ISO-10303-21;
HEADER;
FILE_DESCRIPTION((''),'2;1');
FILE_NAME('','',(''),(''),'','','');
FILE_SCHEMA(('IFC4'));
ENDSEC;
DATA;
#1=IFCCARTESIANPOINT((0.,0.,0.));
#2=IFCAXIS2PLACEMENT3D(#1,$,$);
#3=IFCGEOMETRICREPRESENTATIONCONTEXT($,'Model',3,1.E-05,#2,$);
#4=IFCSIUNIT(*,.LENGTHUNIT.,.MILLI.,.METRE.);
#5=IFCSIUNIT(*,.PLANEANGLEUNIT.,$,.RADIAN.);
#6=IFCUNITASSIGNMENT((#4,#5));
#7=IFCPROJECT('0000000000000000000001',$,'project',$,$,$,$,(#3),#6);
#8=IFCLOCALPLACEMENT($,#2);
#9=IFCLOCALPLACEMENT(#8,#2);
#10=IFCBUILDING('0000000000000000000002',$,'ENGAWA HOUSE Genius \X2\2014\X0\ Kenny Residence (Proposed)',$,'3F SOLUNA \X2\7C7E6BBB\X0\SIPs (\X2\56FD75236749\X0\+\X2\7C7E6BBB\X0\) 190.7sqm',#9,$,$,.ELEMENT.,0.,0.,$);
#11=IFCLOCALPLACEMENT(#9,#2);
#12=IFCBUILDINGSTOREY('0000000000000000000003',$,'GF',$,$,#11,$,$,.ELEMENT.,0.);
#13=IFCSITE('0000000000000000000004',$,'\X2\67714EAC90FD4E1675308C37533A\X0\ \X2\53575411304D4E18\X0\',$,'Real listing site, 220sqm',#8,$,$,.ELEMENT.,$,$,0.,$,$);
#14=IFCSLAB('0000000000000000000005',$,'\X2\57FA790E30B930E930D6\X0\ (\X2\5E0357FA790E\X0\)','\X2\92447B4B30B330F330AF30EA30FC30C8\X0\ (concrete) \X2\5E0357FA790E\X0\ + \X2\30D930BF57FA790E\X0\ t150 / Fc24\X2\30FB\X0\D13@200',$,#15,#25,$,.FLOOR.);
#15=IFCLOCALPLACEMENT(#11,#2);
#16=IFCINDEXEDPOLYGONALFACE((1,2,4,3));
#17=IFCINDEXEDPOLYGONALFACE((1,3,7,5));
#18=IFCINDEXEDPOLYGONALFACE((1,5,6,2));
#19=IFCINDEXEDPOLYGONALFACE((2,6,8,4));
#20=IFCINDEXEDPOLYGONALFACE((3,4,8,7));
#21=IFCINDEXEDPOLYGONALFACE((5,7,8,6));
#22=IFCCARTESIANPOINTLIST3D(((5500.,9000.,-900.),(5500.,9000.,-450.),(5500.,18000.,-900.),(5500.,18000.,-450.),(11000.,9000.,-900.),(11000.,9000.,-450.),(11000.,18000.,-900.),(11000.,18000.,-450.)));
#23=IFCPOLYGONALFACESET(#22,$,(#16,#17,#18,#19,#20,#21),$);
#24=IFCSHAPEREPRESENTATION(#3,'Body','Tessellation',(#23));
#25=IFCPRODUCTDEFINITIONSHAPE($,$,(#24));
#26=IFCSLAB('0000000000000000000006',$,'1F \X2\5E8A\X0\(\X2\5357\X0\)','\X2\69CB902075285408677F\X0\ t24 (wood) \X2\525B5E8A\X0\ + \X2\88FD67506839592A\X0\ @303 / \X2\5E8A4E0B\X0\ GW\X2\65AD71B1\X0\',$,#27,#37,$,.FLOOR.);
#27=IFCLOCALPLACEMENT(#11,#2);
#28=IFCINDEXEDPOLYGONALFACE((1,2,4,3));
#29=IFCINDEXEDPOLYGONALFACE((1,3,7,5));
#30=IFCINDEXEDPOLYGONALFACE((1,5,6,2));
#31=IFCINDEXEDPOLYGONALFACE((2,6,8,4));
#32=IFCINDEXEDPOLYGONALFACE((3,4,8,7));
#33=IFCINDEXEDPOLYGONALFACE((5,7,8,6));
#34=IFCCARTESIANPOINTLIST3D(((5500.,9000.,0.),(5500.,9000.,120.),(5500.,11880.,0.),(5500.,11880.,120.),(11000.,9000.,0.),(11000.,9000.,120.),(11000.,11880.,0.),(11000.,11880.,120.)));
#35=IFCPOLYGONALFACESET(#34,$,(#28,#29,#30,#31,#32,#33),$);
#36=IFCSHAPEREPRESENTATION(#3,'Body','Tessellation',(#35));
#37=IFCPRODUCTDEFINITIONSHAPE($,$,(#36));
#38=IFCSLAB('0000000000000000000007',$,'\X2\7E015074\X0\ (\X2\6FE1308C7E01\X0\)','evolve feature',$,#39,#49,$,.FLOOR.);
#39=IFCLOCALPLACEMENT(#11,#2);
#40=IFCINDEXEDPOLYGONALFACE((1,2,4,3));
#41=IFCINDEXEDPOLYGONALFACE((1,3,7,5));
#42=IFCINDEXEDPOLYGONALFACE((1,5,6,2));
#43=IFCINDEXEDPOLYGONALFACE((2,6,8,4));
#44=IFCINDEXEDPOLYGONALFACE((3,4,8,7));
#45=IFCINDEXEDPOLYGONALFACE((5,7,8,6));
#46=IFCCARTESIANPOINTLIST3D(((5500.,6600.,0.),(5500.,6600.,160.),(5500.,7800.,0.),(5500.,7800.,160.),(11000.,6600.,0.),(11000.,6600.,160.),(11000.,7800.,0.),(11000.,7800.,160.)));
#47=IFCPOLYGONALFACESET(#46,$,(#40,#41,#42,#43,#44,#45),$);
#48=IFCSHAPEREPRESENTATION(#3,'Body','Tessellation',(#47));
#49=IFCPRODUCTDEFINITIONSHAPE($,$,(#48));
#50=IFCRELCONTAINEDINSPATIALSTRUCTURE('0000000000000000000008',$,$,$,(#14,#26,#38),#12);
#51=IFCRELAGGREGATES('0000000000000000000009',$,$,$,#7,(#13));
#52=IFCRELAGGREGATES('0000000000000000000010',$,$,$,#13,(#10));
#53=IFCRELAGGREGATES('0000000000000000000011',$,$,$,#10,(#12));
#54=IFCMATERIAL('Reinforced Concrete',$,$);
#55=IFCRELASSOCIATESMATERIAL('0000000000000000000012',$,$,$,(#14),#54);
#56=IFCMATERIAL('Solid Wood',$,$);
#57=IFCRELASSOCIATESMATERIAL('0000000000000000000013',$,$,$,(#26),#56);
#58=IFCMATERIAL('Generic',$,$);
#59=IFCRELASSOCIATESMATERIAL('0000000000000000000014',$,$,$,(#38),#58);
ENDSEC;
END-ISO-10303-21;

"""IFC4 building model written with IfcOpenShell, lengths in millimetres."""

from ifc_helpers import new_model, si_unit, frame, frame_2d, origin, place, context, project, spatial, rectangle, extrude, material, element, save


model = new_model("IFC4")

# Units and contexts
model_context = context("Model", 3, precision=1e-05, world=origin())
ifc_project = project(units=[si_unit("LENGTHUNIT", "METRE", prefix="MILLI"), si_unit("PLANEANGLEUNIT", "RADIAN")], contexts=[model_context])

# Site, building, storey
site_placement = place(None, origin())
site = spatial("IfcSite", under=ifc_project, at=site_placement, Name="東京都世田谷区 南向き丘", ObjectType="Real listing site, 220sqm", CompositionType="ELEMENT", RefElevation=0.0)
building_placement = place(site_placement, origin())
building = spatial("IfcBuilding", under=site, at=building_placement, Name="ENGAWA HOUSE Genius — Kenny Residence (Proposed)", ObjectType="3F SOLUNA 籾殻SIPs (国産杉+籾殻) 190.7sqm", CompositionType="ELEMENT", ElevationOfRefHeight=0.0, ElevationOfTerrain=0.0)
storey_placement = place(building_placement, origin())
storey = spatial("IfcBuildingStorey", under=building, at=storey_placement, Name="GF", CompositionType="ELEMENT", Elevation=0.0)

# Slabs
ifc_material_1 = material(Name="Reinforced Concrete")
slab_1_placement = place(storey_placement, frame((2750.0, 4500.0, -450.0)))
element("IfcSlab", 1, at=slab_1_placement, inside=storey, material=ifc_material_1, Name="基礎スラブ (布基礎)", Description="鉄筋コンクリート (concrete) 布基礎 + ベタ基礎 t150 / Fc24・D13@200", PredefinedType="FLOOR", context=model_context, shape_type="SweptSolid", body=[
    extrude(rectangle(XDim=5500.0, YDim=9000.0, at=frame_2d((2750.0, 4500.0))), frame((2750.0, 4500.0, -450.0)), (0.0, 0.0, 1.0), 450.0),
])
ifc_material_2 = material(Name="Solid Wood")
slab_2_placement = place(storey_placement, frame((2750.0, 4500.0, 0.0)))
element("IfcSlab", 2, at=slab_2_placement, inside=storey, material=ifc_material_2, Name="1F 床(南)", Description="構造用合板 t24 (wood) 剛床 + 製材根太 @303 / 床下 GW断熱", PredefinedType="FLOOR", context=model_context, shape_type="SweptSolid", body=[
    extrude(rectangle(XDim=5500.0, YDim=2880.0, at=frame_2d((2750.0, 1440.0))), frame((2750.0, 4500.0, 0.0)), (0.0, 0.0, 1.0), 120.0),
])
ifc_material_3 = material(Name="Generic")
slab_3_placement = place(storey_placement, frame((2750.0, 3300.0, 0.0)))
element("IfcSlab", 3, at=slab_3_placement, inside=storey, material=ifc_material_3, Name="縁側 (濡れ縁)", Description="evolve feature", PredefinedType="FLOOR", context=model_context, shape_type="SweptSolid", body=[
    extrude(rectangle(XDim=5500.0, YDim=1200.0, at=frame_2d((2750.0, 600.0))), frame((2750.0, 3300.0, 0.0)), (0.0, 0.0, 1.0), 160.0),
])

save(model, "model.ifc")
